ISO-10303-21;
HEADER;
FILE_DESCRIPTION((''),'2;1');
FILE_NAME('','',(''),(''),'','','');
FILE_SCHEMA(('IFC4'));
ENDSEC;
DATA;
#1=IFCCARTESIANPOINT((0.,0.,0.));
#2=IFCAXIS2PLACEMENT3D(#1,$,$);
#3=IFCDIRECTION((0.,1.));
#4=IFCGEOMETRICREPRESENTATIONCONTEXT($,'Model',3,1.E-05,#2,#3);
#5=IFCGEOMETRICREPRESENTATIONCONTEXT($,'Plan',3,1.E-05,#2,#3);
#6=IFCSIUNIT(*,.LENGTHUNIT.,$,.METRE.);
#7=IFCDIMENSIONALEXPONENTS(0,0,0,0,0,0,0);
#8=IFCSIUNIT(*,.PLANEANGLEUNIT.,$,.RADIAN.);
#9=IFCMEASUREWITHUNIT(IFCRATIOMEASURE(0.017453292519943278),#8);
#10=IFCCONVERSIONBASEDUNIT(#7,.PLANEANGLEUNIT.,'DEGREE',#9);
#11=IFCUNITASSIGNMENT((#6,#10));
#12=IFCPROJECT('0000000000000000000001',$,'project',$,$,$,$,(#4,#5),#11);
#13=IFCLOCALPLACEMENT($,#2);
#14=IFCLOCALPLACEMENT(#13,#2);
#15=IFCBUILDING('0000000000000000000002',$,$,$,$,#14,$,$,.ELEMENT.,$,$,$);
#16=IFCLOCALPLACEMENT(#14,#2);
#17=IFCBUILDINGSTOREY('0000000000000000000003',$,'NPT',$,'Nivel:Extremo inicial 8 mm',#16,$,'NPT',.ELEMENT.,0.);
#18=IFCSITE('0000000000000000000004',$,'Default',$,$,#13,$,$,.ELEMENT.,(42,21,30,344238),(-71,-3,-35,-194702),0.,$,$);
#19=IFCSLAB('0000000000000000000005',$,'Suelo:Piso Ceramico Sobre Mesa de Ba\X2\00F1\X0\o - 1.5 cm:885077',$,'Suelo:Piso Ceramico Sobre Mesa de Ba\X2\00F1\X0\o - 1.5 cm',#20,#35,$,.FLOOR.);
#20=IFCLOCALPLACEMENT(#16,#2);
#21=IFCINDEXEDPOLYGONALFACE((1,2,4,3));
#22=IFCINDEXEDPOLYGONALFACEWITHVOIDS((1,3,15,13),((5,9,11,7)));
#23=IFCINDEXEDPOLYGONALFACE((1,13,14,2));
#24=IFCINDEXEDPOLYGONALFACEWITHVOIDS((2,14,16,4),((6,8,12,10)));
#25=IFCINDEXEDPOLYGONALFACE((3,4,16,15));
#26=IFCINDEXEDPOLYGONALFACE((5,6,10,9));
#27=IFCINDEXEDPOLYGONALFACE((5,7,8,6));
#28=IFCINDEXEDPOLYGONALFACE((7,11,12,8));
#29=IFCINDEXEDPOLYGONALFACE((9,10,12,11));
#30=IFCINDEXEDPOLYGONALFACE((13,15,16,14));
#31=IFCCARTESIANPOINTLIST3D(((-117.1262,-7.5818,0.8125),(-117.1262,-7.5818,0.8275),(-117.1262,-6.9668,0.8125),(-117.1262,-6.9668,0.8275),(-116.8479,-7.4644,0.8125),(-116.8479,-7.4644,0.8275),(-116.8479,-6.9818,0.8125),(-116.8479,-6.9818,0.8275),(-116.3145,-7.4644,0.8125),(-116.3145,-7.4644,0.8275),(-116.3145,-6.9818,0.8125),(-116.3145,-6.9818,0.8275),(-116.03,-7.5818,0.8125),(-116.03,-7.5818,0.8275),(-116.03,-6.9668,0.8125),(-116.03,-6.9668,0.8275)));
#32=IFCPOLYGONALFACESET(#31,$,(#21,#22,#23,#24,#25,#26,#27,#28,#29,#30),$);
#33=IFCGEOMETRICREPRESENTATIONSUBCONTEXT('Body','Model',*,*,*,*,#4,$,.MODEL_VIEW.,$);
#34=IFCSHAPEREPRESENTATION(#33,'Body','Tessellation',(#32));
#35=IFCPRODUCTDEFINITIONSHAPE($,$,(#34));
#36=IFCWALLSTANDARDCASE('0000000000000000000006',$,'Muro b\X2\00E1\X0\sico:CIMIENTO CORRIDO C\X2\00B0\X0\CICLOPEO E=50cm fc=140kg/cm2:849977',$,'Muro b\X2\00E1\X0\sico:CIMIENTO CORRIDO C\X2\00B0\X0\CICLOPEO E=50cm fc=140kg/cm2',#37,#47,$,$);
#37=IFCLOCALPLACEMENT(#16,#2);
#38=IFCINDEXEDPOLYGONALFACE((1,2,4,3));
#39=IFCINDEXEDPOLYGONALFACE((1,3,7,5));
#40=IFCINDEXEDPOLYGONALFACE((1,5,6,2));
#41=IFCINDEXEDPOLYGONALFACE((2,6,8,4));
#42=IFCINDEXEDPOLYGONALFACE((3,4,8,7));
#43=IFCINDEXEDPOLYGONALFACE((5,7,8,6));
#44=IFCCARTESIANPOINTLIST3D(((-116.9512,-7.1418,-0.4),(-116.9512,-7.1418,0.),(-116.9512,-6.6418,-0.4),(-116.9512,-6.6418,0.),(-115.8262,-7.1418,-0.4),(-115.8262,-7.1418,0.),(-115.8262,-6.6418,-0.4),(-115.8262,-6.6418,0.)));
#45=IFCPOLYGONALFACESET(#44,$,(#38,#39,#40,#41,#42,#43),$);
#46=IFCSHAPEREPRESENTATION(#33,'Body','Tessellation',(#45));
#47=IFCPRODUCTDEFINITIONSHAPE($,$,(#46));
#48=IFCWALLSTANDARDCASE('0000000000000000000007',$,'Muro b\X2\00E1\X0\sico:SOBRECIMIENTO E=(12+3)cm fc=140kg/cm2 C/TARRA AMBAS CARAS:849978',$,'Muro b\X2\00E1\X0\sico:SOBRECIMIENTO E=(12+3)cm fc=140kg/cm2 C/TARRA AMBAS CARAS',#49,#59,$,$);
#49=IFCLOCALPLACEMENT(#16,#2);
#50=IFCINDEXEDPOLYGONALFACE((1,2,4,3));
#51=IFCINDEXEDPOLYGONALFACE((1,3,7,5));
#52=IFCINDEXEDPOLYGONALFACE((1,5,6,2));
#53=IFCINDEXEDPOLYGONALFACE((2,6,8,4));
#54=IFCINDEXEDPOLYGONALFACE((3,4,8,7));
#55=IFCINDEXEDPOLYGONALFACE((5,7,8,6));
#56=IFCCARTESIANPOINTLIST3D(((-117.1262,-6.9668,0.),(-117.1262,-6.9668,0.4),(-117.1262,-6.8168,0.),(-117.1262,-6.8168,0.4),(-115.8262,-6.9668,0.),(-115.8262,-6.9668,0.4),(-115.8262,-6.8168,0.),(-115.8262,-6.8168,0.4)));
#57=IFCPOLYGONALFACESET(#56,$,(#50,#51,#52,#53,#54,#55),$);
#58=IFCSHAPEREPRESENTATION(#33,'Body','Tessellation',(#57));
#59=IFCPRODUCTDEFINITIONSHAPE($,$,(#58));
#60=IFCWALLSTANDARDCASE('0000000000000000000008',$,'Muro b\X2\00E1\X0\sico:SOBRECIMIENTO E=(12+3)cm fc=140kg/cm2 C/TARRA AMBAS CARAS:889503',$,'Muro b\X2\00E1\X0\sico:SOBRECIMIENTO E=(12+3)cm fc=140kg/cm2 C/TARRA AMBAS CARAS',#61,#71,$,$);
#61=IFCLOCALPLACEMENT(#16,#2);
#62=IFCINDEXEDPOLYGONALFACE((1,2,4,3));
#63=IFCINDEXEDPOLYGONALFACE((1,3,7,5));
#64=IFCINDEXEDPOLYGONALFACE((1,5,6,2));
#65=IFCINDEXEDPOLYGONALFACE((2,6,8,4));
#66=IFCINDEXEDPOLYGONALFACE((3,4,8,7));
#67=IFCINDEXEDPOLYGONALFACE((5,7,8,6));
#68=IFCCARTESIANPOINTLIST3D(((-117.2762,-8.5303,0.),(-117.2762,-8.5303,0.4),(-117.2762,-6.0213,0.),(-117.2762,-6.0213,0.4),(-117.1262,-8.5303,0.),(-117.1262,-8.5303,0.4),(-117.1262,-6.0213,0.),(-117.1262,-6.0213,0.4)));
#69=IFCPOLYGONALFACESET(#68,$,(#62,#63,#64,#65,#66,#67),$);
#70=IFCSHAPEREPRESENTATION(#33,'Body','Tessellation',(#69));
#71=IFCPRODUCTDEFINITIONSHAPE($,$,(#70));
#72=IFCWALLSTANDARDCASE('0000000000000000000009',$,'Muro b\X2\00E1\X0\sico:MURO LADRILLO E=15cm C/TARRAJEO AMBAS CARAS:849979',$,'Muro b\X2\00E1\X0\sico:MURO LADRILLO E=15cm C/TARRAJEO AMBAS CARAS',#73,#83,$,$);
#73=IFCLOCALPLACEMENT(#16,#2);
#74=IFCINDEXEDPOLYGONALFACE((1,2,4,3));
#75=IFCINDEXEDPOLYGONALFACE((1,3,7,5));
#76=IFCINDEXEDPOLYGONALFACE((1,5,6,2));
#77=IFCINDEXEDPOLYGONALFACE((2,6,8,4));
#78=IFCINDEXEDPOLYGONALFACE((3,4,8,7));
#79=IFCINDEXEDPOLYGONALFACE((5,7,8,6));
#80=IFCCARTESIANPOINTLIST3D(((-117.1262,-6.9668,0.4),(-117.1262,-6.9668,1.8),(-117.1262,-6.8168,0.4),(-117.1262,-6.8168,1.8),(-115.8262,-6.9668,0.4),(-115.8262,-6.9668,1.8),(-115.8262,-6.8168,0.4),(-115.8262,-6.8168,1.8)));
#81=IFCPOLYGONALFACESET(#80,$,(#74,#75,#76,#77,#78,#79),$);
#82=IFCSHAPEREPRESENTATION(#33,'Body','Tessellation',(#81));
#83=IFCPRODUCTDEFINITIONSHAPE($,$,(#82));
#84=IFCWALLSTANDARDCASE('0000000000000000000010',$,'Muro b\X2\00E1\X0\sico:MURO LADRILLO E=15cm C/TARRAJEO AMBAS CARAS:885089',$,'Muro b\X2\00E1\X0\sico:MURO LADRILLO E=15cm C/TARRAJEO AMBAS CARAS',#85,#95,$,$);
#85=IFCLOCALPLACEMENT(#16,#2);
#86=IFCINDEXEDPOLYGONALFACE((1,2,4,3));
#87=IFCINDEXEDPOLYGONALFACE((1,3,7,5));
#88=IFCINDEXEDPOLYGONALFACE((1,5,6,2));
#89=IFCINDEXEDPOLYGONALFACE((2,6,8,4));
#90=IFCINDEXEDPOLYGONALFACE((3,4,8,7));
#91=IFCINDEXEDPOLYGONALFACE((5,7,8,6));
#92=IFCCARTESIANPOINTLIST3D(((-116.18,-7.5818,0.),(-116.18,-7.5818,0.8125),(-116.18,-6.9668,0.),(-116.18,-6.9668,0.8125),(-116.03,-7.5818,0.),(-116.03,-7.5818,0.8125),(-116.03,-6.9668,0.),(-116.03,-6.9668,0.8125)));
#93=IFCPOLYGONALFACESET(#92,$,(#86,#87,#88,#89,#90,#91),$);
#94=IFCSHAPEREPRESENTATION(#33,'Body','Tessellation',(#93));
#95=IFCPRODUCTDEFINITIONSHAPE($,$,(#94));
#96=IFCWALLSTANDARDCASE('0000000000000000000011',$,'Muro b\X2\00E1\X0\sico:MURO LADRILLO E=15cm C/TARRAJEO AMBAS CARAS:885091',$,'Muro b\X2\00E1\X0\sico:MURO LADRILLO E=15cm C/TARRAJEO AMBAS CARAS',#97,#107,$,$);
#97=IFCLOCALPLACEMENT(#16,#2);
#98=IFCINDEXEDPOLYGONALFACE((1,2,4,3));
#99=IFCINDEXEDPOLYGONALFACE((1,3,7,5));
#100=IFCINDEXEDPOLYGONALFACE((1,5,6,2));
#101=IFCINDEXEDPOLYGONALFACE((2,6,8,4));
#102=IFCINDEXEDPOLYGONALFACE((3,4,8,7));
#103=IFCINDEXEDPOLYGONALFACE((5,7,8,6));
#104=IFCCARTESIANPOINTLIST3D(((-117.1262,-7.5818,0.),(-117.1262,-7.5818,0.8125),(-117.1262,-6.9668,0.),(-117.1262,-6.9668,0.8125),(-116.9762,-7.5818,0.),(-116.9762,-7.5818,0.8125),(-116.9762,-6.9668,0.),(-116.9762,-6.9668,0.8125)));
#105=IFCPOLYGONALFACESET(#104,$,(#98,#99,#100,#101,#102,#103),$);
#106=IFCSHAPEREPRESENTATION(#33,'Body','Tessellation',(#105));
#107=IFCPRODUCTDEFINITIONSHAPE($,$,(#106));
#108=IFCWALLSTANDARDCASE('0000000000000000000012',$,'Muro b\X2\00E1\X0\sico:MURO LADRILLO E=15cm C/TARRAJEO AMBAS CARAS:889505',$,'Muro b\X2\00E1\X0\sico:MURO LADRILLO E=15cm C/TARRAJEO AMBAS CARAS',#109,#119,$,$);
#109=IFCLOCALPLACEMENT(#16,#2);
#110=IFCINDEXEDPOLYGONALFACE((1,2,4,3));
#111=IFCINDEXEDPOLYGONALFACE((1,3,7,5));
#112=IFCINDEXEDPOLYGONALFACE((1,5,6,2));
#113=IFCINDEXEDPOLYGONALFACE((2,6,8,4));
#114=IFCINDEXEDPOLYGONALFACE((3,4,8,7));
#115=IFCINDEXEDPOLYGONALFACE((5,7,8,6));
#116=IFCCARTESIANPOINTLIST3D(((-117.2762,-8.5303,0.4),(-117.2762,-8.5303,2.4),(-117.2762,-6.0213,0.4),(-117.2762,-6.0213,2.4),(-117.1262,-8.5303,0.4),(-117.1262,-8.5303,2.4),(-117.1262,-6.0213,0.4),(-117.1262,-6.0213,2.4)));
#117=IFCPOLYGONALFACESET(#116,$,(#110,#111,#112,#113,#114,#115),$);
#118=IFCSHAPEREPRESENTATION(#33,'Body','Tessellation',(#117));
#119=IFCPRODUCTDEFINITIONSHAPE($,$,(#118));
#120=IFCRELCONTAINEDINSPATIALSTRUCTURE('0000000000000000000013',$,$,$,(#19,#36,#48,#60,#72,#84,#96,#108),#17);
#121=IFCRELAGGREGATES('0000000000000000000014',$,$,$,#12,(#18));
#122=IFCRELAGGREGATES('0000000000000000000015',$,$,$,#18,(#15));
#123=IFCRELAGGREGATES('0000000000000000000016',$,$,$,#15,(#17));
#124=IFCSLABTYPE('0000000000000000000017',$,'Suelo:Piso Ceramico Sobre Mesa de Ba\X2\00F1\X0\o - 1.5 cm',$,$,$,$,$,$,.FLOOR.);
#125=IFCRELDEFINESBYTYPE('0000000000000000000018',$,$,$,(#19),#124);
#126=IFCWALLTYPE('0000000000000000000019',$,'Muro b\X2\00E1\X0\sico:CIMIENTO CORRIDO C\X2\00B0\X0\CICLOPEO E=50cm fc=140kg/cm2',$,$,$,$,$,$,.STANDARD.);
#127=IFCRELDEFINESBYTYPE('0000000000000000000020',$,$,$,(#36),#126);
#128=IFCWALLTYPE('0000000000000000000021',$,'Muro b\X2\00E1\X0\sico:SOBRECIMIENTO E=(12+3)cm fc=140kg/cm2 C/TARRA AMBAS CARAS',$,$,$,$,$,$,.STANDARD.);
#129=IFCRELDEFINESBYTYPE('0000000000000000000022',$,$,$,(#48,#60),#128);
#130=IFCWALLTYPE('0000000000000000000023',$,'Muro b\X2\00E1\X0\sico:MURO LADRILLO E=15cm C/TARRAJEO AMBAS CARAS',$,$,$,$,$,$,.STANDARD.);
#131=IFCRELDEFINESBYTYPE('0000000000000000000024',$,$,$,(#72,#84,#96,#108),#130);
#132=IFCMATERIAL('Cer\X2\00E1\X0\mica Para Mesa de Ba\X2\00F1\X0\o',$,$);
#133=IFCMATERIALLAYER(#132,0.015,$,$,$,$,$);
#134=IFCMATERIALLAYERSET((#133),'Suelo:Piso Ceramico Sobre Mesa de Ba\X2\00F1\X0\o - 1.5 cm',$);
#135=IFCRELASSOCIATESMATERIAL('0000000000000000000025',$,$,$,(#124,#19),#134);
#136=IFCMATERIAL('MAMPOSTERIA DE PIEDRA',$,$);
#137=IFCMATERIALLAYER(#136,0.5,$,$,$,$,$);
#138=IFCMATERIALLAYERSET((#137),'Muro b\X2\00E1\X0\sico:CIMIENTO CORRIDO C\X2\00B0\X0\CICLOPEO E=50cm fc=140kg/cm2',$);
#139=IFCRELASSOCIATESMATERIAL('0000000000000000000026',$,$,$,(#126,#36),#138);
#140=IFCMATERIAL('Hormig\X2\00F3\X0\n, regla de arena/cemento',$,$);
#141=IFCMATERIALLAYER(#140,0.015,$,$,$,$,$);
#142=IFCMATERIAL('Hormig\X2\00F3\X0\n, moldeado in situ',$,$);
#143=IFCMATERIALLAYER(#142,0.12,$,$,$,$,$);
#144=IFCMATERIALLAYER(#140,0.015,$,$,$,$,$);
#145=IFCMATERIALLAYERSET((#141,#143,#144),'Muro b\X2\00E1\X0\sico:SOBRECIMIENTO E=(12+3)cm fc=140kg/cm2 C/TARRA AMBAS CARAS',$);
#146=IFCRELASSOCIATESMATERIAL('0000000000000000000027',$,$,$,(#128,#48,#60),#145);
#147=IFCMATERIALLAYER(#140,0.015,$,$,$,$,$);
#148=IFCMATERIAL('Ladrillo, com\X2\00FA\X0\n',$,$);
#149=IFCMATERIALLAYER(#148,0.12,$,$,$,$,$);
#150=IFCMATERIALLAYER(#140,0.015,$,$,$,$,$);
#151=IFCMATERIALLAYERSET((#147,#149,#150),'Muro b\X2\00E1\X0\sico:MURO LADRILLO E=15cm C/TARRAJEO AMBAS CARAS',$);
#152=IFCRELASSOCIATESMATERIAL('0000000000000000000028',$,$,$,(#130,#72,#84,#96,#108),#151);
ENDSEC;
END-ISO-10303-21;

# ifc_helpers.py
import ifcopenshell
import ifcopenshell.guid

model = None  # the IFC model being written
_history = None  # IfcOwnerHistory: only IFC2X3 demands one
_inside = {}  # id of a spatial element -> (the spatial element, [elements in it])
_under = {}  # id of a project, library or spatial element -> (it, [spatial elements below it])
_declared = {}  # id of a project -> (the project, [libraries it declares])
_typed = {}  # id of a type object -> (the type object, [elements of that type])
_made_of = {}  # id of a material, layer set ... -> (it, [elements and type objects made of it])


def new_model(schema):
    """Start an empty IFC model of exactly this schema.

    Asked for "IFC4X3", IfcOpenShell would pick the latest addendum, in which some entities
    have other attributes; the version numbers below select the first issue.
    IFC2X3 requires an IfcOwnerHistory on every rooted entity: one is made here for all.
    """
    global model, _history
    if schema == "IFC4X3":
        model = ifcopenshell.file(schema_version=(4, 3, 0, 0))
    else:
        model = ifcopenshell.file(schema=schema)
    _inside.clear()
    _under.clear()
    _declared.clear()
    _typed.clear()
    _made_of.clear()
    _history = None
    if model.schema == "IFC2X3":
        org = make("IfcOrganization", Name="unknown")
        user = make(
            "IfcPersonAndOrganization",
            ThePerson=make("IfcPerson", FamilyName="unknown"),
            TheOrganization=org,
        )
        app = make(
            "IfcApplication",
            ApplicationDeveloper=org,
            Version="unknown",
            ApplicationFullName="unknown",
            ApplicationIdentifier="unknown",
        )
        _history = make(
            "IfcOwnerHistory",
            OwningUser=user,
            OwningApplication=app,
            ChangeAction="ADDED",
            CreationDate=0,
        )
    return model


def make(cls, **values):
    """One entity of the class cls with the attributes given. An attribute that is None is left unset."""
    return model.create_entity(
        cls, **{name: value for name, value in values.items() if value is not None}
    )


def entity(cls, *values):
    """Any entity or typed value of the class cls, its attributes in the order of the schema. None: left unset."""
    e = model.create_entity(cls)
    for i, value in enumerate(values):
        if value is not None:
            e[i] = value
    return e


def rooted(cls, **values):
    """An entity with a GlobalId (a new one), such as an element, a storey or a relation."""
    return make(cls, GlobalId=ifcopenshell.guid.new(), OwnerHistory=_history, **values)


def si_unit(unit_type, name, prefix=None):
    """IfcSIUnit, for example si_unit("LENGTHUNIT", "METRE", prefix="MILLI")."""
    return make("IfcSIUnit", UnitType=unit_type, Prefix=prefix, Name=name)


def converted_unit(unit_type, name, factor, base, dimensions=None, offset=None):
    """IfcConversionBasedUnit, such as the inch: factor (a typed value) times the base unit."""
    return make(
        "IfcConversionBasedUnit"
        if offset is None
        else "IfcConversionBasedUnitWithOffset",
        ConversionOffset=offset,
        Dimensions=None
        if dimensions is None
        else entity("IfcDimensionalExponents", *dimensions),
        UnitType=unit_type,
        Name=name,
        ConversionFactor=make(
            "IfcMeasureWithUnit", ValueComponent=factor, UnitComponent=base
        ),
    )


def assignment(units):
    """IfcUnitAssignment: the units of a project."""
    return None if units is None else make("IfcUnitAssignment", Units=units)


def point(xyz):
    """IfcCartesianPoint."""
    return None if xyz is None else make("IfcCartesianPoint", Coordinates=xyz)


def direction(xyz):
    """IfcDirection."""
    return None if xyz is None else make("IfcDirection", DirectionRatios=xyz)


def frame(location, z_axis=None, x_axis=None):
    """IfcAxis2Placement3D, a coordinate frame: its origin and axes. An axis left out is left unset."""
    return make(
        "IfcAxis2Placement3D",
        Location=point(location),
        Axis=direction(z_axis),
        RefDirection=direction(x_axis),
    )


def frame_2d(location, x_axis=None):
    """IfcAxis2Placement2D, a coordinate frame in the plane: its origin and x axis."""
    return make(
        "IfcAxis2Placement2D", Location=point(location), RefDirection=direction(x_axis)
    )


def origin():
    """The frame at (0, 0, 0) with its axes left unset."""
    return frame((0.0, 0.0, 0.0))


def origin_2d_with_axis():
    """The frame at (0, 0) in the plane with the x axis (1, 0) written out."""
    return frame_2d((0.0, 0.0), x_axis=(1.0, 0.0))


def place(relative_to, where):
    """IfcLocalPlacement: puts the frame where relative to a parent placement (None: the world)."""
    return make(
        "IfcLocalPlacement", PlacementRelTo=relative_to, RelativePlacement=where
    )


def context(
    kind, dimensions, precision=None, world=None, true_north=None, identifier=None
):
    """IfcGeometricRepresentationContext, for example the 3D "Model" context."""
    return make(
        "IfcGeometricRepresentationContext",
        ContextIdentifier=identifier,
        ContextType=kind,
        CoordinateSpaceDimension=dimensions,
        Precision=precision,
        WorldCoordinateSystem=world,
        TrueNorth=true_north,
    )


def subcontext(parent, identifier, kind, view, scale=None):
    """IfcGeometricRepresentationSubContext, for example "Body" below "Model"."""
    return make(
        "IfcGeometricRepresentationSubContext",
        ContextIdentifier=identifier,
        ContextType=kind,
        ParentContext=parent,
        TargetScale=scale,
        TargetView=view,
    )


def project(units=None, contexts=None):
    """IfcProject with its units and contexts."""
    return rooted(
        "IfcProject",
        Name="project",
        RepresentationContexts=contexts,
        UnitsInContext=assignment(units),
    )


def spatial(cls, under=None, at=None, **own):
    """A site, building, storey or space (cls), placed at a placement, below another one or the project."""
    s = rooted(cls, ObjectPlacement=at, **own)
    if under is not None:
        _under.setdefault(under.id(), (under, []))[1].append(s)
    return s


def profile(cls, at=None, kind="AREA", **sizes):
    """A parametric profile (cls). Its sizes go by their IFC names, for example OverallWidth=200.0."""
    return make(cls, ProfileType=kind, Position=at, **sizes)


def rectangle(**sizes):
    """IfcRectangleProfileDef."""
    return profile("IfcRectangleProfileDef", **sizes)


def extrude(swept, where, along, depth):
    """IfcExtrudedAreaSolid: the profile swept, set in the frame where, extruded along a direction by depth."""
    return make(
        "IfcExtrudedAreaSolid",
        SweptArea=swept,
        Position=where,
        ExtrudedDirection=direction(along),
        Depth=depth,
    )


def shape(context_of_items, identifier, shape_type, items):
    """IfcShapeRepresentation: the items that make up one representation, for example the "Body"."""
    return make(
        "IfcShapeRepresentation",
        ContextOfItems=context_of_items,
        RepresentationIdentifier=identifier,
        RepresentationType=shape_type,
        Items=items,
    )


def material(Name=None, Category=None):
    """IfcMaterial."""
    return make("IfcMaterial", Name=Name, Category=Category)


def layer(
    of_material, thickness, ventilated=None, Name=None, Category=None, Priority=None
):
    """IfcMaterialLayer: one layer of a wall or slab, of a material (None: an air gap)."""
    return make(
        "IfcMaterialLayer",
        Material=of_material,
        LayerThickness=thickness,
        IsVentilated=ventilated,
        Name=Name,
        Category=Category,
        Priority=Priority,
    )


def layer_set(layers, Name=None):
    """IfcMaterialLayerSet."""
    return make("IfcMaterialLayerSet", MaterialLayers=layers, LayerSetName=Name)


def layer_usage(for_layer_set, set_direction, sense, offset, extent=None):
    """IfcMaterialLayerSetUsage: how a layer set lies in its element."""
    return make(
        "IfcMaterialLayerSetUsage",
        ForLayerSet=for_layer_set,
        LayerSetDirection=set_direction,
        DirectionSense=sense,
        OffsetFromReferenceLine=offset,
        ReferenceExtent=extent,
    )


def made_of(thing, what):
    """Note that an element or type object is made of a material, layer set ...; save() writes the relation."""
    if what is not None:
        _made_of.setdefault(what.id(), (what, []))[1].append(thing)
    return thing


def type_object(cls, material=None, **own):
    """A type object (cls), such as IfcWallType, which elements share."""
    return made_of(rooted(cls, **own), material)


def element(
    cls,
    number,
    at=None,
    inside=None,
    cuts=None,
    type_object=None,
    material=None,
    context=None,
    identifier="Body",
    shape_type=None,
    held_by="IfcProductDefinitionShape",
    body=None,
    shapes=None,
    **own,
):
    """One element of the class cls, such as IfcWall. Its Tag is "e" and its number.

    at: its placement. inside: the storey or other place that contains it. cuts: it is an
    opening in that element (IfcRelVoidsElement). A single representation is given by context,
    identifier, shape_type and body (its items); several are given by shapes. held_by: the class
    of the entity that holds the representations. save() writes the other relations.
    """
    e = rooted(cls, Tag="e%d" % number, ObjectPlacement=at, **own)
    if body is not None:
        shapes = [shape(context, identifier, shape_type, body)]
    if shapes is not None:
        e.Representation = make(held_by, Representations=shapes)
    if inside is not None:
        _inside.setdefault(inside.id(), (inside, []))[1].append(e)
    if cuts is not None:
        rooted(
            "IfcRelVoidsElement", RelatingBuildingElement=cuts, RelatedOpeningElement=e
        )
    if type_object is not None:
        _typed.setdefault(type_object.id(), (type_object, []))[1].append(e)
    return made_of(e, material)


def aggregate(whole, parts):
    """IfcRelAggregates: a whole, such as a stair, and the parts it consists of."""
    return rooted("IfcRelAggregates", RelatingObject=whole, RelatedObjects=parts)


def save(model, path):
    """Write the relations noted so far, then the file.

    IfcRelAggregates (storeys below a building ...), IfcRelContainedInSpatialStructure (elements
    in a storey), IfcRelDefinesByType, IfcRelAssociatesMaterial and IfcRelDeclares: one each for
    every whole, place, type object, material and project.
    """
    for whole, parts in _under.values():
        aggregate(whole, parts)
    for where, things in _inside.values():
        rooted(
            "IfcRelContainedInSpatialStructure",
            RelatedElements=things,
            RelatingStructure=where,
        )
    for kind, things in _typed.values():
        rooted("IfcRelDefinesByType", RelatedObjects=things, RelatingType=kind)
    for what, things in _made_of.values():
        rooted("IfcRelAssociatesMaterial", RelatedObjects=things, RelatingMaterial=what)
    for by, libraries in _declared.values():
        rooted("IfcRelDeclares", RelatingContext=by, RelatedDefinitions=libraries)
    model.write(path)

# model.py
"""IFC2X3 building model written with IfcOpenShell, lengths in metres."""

from ifc_helpers import new_model, entity, si_unit, converted_unit, direction, frame, frame_2d, origin, origin_2d_with_axis, place, context, subcontext, project, spatial, rectangle, extrude, material, layer, layer_set, layer_usage, type_object, element, save


model = new_model("IFC2X3")

# Units and contexts
model_context = context("Model", 3, precision=1e-05, world=origin(), true_north=direction((0.0, 1.0)))
plan_context = context("Plan", 3, precision=1e-05, world=origin(), true_north=direction((0.0, 1.0)))
body_context = subcontext(model_context, "Body", "Model", "MODEL_VIEW")
ifc_project = project(units=[si_unit("LENGTHUNIT", "METRE"), converted_unit("PLANEANGLEUNIT", "DEGREE", entity("IfcRatioMeasure", 0.017453292519943278), si_unit("PLANEANGLEUNIT", "RADIAN"), dimensions=[0, 0, 0, 0, 0, 0, 0])], contexts=[model_context, plan_context])

# Site, building, storey
site_placement = place(None, origin())
site = spatial("IfcSite", under=ifc_project, at=site_placement, Name="Default", CompositionType="ELEMENT", RefLatitude=(42, 21, 30, 344238), RefLongitude=(-71, -3, -35, -194702), RefElevation=0.0)
building_placement = place(site_placement, origin())
building = spatial("IfcBuilding", under=site, at=building_placement, CompositionType="ELEMENT")
storey_placement = place(building_placement, origin())
storey = spatial("IfcBuildingStorey", under=building, at=storey_placement, Name="NPT", ObjectType="Nivel:Extremo inicial 8 mm", LongName="NPT", CompositionType="ELEMENT", Elevation=0.0)

# Slab, opening
ifc_material_1 = material(Name="Cerámica Para Mesa de Baño")
ifc_layer_1 = layer(ifc_material_1, 0.015)
ifc_layer_set_1 = layer_set([ifc_layer_1], Name="Suelo:Piso Ceramico Sobre Mesa de Baño - 1.5 cm")
ifc_layer_usage_1 = layer_usage(ifc_layer_set_1, "AXIS3", "POSITIVE", 0.0)
slab_type = type_object("IfcSlabType", Name="Suelo:Piso Ceramico Sobre Mesa de Baño - 1.5 cm", PredefinedType="FLOOR", material=ifc_layer_set_1)
slab_placement = place(storey_placement, frame((-117.1262, -7.5818, 0.8125)))
slab = element("IfcSlab", 1, at=slab_placement, inside=storey, type_object=slab_type, material=ifc_layer_usage_1, Name="Suelo:Piso Ceramico Sobre Mesa de Baño - 1.5 cm:885077", ObjectType="Suelo:Piso Ceramico Sobre Mesa de Baño - 1.5 cm", PredefinedType="FLOOR", context=body_context, shape_type="SweptSolid", body=[
    extrude(rectangle(XDim=1.0962, YDim=0.615, at=origin_2d_with_axis()), frame((0.5481, 0.3075, 0.015), z_axis=(0.0, 0.0, -1.0), x_axis=(-1.0, 0.0, 0.0)), (0.0, 0.0, 1.0), 0.015),
])
opening_placement = place(slab_placement, frame((0.545, 0.3587, 0.015)))
element("IfcOpeningElement", 2, at=opening_placement, cuts=slab, ObjectType="Opening", context=body_context, shape_type="SweptSolid", body=[
    extrude(rectangle(XDim=0.4826, YDim=0.5334, at=origin_2d_with_axis()), frame((0.0, 0.0, 0.0), z_axis=(0.0, 0.0, -1.0), x_axis=(0.0, 1.0, 0.0)), (0.0, 0.0, 1.0), 0.015),
])

# Walls
ifc_material_2 = material(Name="MAMPOSTERIA DE PIEDRA")
ifc_layer_2 = layer(ifc_material_2, 0.5)
ifc_layer_set_2 = layer_set([ifc_layer_2], Name="Muro básico:CIMIENTO CORRIDO C°CICLOPEO E=50cm fc=140kg/cm2")
ifc_layer_usage_2 = layer_usage(ifc_layer_set_2, "AXIS2", "POSITIVE", -0.25)
wall_type_1 = type_object("IfcWallType", Name="Muro básico:CIMIENTO CORRIDO C°CICLOPEO E=50cm fc=140kg/cm2", PredefinedType="STANDARD", material=ifc_layer_set_2)
wall_1_placement = place(storey_placement, frame((-116.9512, -6.8918, -0.4)))
element("IfcWallStandardCase", 3, at=wall_1_placement, inside=storey, type_object=wall_type_1, material=ifc_layer_usage_2, Name="Muro básico:CIMIENTO CORRIDO C°CICLOPEO E=50cm fc=140kg/cm2:849977", ObjectType="Muro básico:CIMIENTO CORRIDO C°CICLOPEO E=50cm fc=140kg/cm2", context=body_context, shape_type="SweptSolid", body=[
    extrude(rectangle(XDim=1.125, YDim=0.5, at=frame_2d((0.5625, 0.0), x_axis=(-1.0, 0.0))), origin(), (0.0, 0.0, 1.0), 0.4),
])
ifc_material_3 = material(Name="Hormigón, regla de arena/cemento")
ifc_layer_3 = layer(ifc_material_3, 0.015)
ifc_material_4 = material(Name="Hormigón, moldeado in situ")
ifc_layer_4 = layer(ifc_material_4, 0.12)
ifc_layer_5 = layer(ifc_material_3, 0.015)
ifc_layer_set_3 = layer_set([ifc_layer_3, ifc_layer_4, ifc_layer_5], Name="Muro básico:SOBRECIMIENTO E=(12+3)cm fc=140kg/cm2 C/TARRA AMBAS CARAS")
ifc_layer_usage_3 = layer_usage(ifc_layer_set_3, "AXIS2", "POSITIVE", -0.075)
wall_type_2 = type_object("IfcWallType", Name="Muro básico:SOBRECIMIENTO E=(12+3)cm fc=140kg/cm2 C/TARRA AMBAS CARAS", PredefinedType="STANDARD", material=ifc_layer_set_3)
wall_2_placement = place(storey_placement, frame((-117.1262, -6.8918, 0.0)))
element("IfcWallStandardCase", 4, at=wall_2_placement, inside=storey, type_object=wall_type_2, material=ifc_layer_usage_3, Name="Muro básico:SOBRECIMIENTO E=(12+3)cm fc=140kg/cm2 C/TARRA AMBAS CARAS:849978", ObjectType="Muro básico:SOBRECIMIENTO E=(12+3)cm fc=140kg/cm2 C/TARRA AMBAS CARAS", context=body_context, shape_type="SweptSolid", body=[
    extrude(rectangle(XDim=1.3, YDim=0.15, at=frame_2d((0.65, 0.0), x_axis=(-1.0, 0.0))), origin(), (0.0, 0.0, 1.0), 0.4),
])
ifc_layer_usage_4 = layer_usage(ifc_layer_set_3, "AXIS2", "NEGATIVE", 0.075)
wall_3_placement = place(storey_placement, frame((-117.2012, -8.5303, 0.0), z_axis=(0.0, 0.0, 1.0), x_axis=(0.0, 1.0, 0.0)))
element("IfcWallStandardCase", 5, at=wall_3_placement, inside=storey, type_object=wall_type_2, material=ifc_layer_usage_4, Name="Muro básico:SOBRECIMIENTO E=(12+3)cm fc=140kg/cm2 C/TARRA AMBAS CARAS:889503", ObjectType="Muro básico:SOBRECIMIENTO E=(12+3)cm fc=140kg/cm2 C/TARRA AMBAS CARAS", context=body_context, shape_type="SweptSolid", body=[
    extrude(rectangle(XDim=2.5091, YDim=0.15, at=frame_2d((1.2545, 0.0), x_axis=(-1.0, 0.0))), origin(), (0.0, 0.0, 1.0), 0.4),
])
ifc_layer_6 = layer(ifc_material_3, 0.015)
ifc_material_5 = material(Name="Ladrillo, común")
ifc_layer_7 = layer(ifc_material_5, 0.12)
ifc_layer_8 = layer(ifc_material_3, 0.015)
ifc_layer_set_4 = layer_set([ifc_layer_6, ifc_layer_7, ifc_layer_8], Name="Muro básico:MURO LADRILLO E=15cm C/TARRAJEO AMBAS CARAS")
ifc_layer_usage_5 = layer_usage(ifc_layer_set_4, "AXIS2", "POSITIVE", -0.075)
wall_type_3 = type_object("IfcWallType", Name="Muro básico:MURO LADRILLO E=15cm C/TARRAJEO AMBAS CARAS", PredefinedType="STANDARD", material=ifc_layer_set_4)
wall_4_placement = place(storey_placement, frame((-117.1262, -6.8918, 0.4)))
element("IfcWallStandardCase", 6, at=wall_4_placement, inside=storey, type_object=wall_type_3, material=ifc_layer_usage_5, Name="Muro básico:MURO LADRILLO E=15cm C/TARRAJEO AMBAS CARAS:849979", ObjectType="Muro básico:MURO LADRILLO E=15cm C/TARRAJEO AMBAS CARAS", context=body_context, shape_type="SweptSolid", body=[
    extrude(rectangle(XDim=1.3, YDim=0.15, at=frame_2d((0.65, 0.0), x_axis=(-1.0, 0.0))), origin(), (0.0, 0.0, 1.0), 1.4),
])
ifc_layer_usage_6 = layer_usage(ifc_layer_set_4, "AXIS2", "POSITIVE", -0.075)
wall_5_placement = place(storey_placement, frame((-116.105, -7.5818, 0.0), z_axis=(0.0, 0.0, 1.0), x_axis=(0.0, 1.0, 0.0)))
element("IfcWallStandardCase", 7, at=wall_5_placement, inside=storey, type_object=wall_type_3, material=ifc_layer_usage_6, Name="Muro básico:MURO LADRILLO E=15cm C/TARRAJEO AMBAS CARAS:885089", ObjectType="Muro básico:MURO LADRILLO E=15cm C/TARRAJEO AMBAS CARAS", context=body_context, shape_type="SweptSolid", body=[
    extrude(rectangle(XDim=0.615, YDim=0.15, at=frame_2d((0.3075, 0.0), x_axis=(-1.0, 0.0))), origin(), (0.0, 0.0, 1.0), 0.8125),
])
ifc_layer_usage_7 = layer_usage(ifc_layer_set_4, "AXIS2", "POSITIVE", -0.075)
wall_6_placement = place(storey_placement, frame((-117.0512, -7.5818, 0.0), z_axis=(0.0, 0.0, 1.0), x_axis=(0.0, 1.0, 0.0)))
element("IfcWallStandardCase", 8, at=wall_6_placement, inside=storey, type_object=wall_type_3, material=ifc_layer_usage_7, Name="Muro básico:MURO LADRILLO E=15cm C/TARRAJEO AMBAS CARAS:885091", ObjectType="Muro básico:MURO LADRILLO E=15cm C/TARRAJEO AMBAS CARAS", context=body_context, shape_type="SweptSolid", body=[
    extrude(rectangle(XDim=0.615, YDim=0.15, at=frame_2d((0.3075, 0.0), x_axis=(-1.0, 0.0))), origin(), (0.0, 0.0, 1.0), 0.8125),
])
ifc_layer_usage_8 = layer_usage(ifc_layer_set_4, "AXIS2", "NEGATIVE", 0.075)
wall_7_placement = place(storey_placement, frame((-117.2012, -8.5303, 0.4), z_axis=(0.0, 0.0, 1.0), x_axis=(0.0, 1.0, 0.0)))
element("IfcWallStandardCase", 9, at=wall_7_placement, inside=storey, type_object=wall_type_3, material=ifc_layer_usage_8, Name="Muro básico:MURO LADRILLO E=15cm C/TARRAJEO AMBAS CARAS:889505", ObjectType="Muro básico:MURO LADRILLO E=15cm C/TARRAJEO AMBAS CARAS", context=body_context, shape_type="SweptSolid", body=[
    extrude(rectangle(XDim=2.5091, YDim=0.15, at=frame_2d((1.2545, 0.0), x_axis=(-1.0, 0.0))), origin(), (0.0, 0.0, 1.0), 2.0),
])

save(model, "model.ifc")
